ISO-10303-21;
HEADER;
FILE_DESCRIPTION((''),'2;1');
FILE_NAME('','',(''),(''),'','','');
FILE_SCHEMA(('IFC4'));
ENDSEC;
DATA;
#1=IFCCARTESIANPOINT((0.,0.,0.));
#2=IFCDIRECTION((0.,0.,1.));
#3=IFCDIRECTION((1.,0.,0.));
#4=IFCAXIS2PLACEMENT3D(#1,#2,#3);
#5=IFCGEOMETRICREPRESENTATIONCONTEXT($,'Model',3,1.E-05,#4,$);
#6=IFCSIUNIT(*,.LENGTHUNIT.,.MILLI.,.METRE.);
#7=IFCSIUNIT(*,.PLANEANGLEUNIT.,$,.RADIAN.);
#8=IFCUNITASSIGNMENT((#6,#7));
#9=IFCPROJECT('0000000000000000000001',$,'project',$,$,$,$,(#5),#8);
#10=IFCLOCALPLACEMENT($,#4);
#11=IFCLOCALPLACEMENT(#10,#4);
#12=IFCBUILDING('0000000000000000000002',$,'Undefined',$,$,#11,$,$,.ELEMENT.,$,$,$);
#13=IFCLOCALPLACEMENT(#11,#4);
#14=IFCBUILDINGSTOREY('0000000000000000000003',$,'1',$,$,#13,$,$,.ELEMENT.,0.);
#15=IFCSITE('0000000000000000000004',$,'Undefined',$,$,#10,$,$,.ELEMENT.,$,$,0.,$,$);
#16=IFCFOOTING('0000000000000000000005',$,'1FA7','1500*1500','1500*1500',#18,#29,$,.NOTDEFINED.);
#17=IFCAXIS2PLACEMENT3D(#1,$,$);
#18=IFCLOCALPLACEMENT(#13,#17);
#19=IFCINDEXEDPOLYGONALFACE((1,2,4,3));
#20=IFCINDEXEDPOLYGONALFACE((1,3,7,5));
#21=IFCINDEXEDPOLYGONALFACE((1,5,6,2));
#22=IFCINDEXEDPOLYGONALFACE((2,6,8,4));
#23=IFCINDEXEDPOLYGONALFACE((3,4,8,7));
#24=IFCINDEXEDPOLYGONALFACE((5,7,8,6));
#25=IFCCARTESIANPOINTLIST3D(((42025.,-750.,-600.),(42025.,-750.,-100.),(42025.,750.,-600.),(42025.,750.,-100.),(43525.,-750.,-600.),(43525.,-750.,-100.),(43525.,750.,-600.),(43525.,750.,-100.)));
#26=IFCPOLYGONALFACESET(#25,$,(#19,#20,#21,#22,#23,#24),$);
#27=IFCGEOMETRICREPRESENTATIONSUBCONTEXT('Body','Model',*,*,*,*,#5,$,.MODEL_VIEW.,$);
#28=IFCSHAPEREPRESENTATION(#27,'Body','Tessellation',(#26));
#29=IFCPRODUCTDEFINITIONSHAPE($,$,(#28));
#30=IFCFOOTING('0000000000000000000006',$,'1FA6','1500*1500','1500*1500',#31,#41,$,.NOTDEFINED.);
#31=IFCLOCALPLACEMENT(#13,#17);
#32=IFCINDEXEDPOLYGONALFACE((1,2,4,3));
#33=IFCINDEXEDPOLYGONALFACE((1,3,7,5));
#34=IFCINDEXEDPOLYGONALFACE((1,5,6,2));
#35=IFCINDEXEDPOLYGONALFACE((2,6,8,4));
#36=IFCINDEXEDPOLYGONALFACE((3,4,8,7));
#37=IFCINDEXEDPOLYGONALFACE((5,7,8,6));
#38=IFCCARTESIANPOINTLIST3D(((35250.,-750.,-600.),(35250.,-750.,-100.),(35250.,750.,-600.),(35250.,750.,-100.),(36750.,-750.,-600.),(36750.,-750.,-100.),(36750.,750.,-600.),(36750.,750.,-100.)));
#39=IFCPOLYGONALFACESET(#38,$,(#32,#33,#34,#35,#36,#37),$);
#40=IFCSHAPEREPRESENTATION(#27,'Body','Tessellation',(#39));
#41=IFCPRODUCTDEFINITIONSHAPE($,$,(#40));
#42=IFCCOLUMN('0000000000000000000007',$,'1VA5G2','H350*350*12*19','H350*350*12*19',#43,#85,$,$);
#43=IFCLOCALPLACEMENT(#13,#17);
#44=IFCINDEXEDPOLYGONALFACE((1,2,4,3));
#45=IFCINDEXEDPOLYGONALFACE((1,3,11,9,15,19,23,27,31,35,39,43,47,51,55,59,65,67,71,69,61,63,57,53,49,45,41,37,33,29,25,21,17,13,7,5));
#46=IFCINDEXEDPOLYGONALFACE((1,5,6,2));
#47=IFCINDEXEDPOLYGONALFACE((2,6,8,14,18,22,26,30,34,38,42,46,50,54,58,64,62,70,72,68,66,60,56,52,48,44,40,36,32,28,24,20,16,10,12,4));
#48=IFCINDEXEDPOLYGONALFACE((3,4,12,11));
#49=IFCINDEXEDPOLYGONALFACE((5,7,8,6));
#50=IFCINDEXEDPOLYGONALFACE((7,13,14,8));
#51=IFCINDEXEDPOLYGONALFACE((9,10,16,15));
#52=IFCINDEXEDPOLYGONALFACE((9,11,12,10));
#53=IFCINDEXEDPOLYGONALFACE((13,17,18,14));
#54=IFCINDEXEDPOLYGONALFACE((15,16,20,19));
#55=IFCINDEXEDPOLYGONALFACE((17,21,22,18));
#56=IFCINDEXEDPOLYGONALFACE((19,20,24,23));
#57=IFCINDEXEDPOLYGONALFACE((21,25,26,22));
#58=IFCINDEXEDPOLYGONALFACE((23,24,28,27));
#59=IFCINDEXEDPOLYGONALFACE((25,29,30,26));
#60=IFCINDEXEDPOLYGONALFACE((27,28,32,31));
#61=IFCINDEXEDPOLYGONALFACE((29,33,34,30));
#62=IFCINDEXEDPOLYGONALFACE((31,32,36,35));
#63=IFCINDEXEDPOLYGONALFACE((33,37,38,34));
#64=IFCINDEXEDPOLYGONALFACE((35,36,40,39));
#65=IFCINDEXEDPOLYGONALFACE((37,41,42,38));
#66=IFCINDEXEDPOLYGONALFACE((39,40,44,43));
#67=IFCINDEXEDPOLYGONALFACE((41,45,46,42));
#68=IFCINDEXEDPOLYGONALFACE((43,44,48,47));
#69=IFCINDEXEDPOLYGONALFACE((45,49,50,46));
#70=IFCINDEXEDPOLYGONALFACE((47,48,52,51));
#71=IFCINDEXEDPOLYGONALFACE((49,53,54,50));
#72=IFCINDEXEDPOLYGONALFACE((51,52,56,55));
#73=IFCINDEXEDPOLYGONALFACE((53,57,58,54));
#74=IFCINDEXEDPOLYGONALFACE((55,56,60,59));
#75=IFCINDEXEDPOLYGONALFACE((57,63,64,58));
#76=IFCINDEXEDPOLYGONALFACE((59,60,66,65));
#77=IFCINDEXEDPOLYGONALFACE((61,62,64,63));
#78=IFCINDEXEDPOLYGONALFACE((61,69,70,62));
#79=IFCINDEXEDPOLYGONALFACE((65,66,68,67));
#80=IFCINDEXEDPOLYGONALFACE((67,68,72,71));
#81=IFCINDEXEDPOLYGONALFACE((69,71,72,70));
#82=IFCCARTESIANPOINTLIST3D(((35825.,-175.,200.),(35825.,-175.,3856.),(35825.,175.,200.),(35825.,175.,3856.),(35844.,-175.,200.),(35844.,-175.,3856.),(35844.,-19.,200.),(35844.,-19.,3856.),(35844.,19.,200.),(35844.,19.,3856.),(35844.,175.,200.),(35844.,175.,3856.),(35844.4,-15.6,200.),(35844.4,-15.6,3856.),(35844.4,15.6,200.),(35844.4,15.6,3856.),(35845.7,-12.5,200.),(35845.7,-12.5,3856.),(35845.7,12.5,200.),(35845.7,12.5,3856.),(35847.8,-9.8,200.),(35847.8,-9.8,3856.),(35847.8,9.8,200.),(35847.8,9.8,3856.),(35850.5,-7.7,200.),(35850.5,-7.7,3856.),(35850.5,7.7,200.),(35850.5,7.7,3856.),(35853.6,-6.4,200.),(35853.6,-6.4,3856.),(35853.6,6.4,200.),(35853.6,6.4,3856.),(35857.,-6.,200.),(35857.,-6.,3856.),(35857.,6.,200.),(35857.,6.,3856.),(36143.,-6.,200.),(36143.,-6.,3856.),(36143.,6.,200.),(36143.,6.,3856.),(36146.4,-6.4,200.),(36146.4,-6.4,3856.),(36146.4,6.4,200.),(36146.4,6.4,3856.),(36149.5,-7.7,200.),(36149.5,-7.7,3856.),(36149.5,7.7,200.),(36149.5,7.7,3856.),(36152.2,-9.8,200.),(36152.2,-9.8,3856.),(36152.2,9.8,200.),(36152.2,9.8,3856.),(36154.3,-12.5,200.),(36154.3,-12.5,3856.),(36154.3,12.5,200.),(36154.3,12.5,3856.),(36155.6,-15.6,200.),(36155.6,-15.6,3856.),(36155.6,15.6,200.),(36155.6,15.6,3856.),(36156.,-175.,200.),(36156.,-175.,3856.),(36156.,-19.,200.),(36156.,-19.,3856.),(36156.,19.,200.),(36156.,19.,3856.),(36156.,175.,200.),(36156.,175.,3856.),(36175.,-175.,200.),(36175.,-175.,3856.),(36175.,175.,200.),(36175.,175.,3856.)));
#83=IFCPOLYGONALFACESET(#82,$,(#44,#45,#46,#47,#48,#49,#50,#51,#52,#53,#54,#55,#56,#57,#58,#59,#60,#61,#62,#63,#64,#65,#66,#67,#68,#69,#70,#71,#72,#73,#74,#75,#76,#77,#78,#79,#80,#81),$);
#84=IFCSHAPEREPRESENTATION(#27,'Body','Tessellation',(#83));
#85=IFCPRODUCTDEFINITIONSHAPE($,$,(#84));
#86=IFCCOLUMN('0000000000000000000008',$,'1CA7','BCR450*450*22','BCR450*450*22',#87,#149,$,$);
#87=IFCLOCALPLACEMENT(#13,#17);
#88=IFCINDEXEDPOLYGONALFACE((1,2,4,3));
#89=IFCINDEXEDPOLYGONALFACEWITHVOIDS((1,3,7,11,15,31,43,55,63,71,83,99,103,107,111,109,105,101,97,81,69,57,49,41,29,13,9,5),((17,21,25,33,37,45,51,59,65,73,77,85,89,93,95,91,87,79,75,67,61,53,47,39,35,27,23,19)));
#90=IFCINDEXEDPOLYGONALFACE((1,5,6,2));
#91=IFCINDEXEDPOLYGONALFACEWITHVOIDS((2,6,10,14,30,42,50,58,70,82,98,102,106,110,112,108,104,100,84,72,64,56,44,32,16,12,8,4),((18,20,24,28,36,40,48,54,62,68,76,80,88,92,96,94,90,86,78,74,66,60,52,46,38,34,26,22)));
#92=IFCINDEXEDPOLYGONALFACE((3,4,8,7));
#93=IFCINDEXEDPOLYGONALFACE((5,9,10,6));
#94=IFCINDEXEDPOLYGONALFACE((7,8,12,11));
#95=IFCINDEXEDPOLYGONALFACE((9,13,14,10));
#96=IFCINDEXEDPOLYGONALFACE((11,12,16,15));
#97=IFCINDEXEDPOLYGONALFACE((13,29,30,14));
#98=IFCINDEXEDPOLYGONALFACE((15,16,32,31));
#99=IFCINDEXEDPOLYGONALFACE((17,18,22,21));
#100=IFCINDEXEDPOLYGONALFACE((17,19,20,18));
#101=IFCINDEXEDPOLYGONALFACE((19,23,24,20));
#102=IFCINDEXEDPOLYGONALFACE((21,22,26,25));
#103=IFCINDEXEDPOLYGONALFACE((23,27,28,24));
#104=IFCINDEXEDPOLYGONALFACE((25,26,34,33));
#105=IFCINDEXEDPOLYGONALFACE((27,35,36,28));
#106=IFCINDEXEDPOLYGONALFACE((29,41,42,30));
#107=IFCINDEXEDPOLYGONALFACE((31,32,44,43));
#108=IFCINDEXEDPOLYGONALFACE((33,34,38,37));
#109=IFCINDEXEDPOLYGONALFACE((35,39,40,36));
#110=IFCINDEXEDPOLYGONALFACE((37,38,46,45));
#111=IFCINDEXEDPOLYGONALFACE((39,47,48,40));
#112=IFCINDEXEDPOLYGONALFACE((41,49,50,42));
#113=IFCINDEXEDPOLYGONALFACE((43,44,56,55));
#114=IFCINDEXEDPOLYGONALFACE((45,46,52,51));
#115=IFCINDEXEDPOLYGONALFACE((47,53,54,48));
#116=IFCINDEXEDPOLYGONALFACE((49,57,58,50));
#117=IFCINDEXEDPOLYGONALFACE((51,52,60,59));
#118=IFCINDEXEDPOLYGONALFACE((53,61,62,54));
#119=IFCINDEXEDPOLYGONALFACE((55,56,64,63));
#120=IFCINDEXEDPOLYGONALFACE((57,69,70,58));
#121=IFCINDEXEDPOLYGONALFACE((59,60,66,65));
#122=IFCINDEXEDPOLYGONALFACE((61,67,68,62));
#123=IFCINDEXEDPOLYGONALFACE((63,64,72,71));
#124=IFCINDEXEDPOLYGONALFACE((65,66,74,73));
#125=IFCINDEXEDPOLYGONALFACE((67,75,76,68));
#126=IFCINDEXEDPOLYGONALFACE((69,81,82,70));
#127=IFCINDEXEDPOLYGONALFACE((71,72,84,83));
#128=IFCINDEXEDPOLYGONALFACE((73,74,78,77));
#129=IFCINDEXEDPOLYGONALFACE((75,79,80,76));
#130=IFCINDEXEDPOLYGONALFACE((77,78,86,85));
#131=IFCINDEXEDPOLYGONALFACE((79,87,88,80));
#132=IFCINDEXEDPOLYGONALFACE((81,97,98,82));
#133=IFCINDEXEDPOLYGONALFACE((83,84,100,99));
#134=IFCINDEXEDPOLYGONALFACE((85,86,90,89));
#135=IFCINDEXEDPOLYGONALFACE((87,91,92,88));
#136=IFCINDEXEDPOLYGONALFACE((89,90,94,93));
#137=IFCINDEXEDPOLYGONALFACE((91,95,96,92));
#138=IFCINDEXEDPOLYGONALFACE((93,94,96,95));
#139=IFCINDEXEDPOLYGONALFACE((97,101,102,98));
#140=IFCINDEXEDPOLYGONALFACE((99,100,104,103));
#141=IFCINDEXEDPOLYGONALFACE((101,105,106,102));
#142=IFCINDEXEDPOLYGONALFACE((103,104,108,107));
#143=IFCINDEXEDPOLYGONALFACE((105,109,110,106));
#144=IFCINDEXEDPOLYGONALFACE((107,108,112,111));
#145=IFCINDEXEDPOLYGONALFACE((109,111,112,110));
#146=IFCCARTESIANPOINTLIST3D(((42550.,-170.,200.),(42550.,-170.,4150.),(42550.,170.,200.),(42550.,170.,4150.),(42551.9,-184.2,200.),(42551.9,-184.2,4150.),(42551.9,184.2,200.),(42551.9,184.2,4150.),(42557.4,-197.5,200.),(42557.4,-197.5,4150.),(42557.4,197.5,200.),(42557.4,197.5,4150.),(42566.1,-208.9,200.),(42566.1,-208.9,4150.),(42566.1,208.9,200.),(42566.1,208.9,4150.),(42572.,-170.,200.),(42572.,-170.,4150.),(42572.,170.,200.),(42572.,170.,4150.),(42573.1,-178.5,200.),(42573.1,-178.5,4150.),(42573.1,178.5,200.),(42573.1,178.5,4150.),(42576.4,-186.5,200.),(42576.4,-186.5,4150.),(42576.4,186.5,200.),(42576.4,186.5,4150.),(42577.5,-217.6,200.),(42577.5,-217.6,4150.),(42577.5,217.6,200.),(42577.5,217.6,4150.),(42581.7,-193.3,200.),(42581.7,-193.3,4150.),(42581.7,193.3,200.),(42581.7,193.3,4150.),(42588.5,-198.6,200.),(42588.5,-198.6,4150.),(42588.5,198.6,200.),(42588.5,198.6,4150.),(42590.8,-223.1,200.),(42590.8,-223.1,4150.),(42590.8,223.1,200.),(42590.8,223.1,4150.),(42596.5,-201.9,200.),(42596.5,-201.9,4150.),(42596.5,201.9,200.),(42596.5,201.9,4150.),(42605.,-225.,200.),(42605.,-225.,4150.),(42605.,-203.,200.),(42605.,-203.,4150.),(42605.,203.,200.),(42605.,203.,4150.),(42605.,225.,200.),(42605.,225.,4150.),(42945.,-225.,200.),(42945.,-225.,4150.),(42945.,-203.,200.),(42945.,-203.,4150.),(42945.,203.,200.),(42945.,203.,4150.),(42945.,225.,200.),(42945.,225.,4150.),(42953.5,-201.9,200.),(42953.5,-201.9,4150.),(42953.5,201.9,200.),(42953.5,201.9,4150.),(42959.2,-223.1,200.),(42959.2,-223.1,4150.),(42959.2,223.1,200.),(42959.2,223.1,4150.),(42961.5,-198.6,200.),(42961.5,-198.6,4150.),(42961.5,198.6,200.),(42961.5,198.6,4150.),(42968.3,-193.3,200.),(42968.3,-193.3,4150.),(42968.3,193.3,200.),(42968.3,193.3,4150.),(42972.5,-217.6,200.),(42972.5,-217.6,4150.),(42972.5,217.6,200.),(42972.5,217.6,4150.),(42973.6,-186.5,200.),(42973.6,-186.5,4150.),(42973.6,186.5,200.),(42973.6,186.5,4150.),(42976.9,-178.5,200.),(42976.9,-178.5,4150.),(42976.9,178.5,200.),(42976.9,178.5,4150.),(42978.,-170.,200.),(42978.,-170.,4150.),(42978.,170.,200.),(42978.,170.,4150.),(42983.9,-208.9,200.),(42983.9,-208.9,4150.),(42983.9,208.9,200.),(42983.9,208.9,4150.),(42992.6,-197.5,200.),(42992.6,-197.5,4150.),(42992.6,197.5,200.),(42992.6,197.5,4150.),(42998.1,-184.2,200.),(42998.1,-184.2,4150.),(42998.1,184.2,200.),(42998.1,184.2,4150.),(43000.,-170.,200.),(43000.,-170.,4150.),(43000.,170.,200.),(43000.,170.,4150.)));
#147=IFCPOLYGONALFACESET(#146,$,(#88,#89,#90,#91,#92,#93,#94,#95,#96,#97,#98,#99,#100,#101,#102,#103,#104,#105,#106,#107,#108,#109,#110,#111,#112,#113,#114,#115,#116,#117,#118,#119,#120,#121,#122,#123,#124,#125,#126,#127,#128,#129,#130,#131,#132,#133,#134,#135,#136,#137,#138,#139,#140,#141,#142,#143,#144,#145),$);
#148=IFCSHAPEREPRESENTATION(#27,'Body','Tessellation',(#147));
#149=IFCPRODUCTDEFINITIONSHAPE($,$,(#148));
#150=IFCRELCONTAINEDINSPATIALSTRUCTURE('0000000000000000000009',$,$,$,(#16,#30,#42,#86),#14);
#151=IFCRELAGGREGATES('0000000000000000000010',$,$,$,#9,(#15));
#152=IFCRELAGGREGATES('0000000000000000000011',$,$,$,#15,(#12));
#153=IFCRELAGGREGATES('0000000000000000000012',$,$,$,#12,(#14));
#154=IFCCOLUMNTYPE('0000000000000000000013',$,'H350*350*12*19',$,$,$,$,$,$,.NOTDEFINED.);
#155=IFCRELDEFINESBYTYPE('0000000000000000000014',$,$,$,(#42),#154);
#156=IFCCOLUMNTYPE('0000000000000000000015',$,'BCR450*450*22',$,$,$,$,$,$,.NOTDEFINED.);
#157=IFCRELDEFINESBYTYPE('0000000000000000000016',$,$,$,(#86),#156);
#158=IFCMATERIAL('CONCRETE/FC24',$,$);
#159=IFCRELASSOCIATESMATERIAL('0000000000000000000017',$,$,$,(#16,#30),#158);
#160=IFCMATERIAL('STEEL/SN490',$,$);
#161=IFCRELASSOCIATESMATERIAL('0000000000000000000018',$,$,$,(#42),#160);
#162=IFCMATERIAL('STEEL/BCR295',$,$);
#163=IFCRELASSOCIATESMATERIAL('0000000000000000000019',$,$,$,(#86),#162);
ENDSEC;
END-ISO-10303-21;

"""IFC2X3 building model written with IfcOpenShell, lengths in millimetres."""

from ifc_helpers import new_model, si_unit, frame, origin_with_axes, origin_2d_with_axis, place, context, subcontext, project, spatial, rectangle, hollow_rectangle, i_section, extrude, material, type_object, element, save


model = new_model("IFC2X3")

# Units and contexts
model_context = context("Model", 3, precision=1e-05, world=origin_with_axes())
body_context = subcontext(model_context, "Body", "Model", "MODEL_VIEW")
ifc_project = project(units=[si_unit("LENGTHUNIT", "METRE", prefix="MILLI"), si_unit("PLANEANGLEUNIT", "RADIAN")], contexts=[model_context])

# Site, building, storey
site_placement = place(None, origin_with_axes())
site = spatial("IfcSite", under=ifc_project, at=site_placement, Name="Undefined", CompositionType="ELEMENT", RefElevation=0.0)
building_placement = place(site_placement, origin_with_axes())
building = spatial("IfcBuilding", under=site, at=building_placement, Name="Undefined", CompositionType="ELEMENT")
storey_placement = place(building_placement, origin_with_axes())
storey = spatial("IfcBuildingStorey", under=building, at=storey_placement, Name="1", CompositionType="ELEMENT", Elevation=0.0)

# Footings
ifc_material_1 = material(Name="CONCRETE/FC24")
for number, where, z_axis, x_axis, name in (
    (1, (42775.0, 0.0, -600.0), (0.0, 1.0, 0.0), (0.0, 0.0, 1.0), "1FA7"),
    (2, (36000.0, 0.0, -600.0), (0.0, 1.0, 0.0), (0.0, 0.0, 1.0), "1FA6"),
):
    element("IfcFooting", number, at=place(storey_placement, frame(where, z_axis=z_axis, x_axis=x_axis)), inside=storey, material=ifc_material_1, Name=name, Description="1500*1500", ObjectType="1500*1500", PredefinedType="NOTDEFINED", context=body_context, shape_type="SweptSolid", body=[
        extrude(rectangle(XDim=1500.0, YDim=1500.0, at=origin_2d_with_axis()), frame((500.0, 0.0, 0.0), z_axis=(-1.0, 0.0, 0.0), x_axis=(0.0, -1.0, 0.0)), (0.0, 0.0, 1.0), 500.0),
    ])

# Columns
ifc_material_2 = material(Name="STEEL/SN490")
column_type_1 = type_object("IfcColumnType", Name="H350*350*12*19", PredefinedType="NOTDEFINED")
column_placement = place(storey_placement, frame((36000.0, 0.0, 200.0), z_axis=(0.0, 0.0, 1.0), x_axis=(-1.0, 0.0, 0.0)))
element("IfcColumn", 3, at=column_placement, inside=storey, type_object=column_type_1, material=ifc_material_2, Name="1VA5G2", Description="H350*350*12*19", ObjectType="H350*350*12*19", context=body_context, shape_type="SweptSolid", body=[
    extrude(i_section(OverallWidth=350.0, OverallDepth=350.0, WebThickness=12.0, FlangeThickness=19.0, FilletRadius=13.0, at=origin_2d_with_axis()), frame((0.0, 0.0, 3656.0), z_axis=(0.0, 0.0, -1.0), x_axis=(0.0, 1.0, 0.0)), (0.0, 0.0, 1.0), 3656.0),
])
ifc_material_3 = material(Name="STEEL/BCR295")
column_type_2 = type_object("IfcColumnType", Name="BCR450*450*22", PredefinedType="NOTDEFINED")
for number, where, z_axis, x_axis, name in (
    (4, (42775.0, 0.0, 200.0), (0.0, 0.0, 1.0), (0.0, 1.0, 0.0), "1CA7"),
):
    element("IfcColumn", number, at=place(storey_placement, frame(where, z_axis=z_axis, x_axis=x_axis)), inside=storey, type_object=column_type_2, material=ifc_material_3, Name=name, Description="BCR450*450*22", ObjectType="BCR450*450*22", context=body_context, shape_type="SweptSolid", body=[
        extrude(hollow_rectangle(XDim=450.0, YDim=450.0, WallThickness=22.0, InnerFilletRadius=33.0, OuterFilletRadius=55.0, at=origin_2d_with_axis()), frame((0.0, 0.0, 3950.0), z_axis=(0.0, 0.0, -1.0), x_axis=(0.0, 1.0, 0.0)), (0.0, 0.0, 1.0), 3950.0),
    ])

save(model, "model.ifc")
